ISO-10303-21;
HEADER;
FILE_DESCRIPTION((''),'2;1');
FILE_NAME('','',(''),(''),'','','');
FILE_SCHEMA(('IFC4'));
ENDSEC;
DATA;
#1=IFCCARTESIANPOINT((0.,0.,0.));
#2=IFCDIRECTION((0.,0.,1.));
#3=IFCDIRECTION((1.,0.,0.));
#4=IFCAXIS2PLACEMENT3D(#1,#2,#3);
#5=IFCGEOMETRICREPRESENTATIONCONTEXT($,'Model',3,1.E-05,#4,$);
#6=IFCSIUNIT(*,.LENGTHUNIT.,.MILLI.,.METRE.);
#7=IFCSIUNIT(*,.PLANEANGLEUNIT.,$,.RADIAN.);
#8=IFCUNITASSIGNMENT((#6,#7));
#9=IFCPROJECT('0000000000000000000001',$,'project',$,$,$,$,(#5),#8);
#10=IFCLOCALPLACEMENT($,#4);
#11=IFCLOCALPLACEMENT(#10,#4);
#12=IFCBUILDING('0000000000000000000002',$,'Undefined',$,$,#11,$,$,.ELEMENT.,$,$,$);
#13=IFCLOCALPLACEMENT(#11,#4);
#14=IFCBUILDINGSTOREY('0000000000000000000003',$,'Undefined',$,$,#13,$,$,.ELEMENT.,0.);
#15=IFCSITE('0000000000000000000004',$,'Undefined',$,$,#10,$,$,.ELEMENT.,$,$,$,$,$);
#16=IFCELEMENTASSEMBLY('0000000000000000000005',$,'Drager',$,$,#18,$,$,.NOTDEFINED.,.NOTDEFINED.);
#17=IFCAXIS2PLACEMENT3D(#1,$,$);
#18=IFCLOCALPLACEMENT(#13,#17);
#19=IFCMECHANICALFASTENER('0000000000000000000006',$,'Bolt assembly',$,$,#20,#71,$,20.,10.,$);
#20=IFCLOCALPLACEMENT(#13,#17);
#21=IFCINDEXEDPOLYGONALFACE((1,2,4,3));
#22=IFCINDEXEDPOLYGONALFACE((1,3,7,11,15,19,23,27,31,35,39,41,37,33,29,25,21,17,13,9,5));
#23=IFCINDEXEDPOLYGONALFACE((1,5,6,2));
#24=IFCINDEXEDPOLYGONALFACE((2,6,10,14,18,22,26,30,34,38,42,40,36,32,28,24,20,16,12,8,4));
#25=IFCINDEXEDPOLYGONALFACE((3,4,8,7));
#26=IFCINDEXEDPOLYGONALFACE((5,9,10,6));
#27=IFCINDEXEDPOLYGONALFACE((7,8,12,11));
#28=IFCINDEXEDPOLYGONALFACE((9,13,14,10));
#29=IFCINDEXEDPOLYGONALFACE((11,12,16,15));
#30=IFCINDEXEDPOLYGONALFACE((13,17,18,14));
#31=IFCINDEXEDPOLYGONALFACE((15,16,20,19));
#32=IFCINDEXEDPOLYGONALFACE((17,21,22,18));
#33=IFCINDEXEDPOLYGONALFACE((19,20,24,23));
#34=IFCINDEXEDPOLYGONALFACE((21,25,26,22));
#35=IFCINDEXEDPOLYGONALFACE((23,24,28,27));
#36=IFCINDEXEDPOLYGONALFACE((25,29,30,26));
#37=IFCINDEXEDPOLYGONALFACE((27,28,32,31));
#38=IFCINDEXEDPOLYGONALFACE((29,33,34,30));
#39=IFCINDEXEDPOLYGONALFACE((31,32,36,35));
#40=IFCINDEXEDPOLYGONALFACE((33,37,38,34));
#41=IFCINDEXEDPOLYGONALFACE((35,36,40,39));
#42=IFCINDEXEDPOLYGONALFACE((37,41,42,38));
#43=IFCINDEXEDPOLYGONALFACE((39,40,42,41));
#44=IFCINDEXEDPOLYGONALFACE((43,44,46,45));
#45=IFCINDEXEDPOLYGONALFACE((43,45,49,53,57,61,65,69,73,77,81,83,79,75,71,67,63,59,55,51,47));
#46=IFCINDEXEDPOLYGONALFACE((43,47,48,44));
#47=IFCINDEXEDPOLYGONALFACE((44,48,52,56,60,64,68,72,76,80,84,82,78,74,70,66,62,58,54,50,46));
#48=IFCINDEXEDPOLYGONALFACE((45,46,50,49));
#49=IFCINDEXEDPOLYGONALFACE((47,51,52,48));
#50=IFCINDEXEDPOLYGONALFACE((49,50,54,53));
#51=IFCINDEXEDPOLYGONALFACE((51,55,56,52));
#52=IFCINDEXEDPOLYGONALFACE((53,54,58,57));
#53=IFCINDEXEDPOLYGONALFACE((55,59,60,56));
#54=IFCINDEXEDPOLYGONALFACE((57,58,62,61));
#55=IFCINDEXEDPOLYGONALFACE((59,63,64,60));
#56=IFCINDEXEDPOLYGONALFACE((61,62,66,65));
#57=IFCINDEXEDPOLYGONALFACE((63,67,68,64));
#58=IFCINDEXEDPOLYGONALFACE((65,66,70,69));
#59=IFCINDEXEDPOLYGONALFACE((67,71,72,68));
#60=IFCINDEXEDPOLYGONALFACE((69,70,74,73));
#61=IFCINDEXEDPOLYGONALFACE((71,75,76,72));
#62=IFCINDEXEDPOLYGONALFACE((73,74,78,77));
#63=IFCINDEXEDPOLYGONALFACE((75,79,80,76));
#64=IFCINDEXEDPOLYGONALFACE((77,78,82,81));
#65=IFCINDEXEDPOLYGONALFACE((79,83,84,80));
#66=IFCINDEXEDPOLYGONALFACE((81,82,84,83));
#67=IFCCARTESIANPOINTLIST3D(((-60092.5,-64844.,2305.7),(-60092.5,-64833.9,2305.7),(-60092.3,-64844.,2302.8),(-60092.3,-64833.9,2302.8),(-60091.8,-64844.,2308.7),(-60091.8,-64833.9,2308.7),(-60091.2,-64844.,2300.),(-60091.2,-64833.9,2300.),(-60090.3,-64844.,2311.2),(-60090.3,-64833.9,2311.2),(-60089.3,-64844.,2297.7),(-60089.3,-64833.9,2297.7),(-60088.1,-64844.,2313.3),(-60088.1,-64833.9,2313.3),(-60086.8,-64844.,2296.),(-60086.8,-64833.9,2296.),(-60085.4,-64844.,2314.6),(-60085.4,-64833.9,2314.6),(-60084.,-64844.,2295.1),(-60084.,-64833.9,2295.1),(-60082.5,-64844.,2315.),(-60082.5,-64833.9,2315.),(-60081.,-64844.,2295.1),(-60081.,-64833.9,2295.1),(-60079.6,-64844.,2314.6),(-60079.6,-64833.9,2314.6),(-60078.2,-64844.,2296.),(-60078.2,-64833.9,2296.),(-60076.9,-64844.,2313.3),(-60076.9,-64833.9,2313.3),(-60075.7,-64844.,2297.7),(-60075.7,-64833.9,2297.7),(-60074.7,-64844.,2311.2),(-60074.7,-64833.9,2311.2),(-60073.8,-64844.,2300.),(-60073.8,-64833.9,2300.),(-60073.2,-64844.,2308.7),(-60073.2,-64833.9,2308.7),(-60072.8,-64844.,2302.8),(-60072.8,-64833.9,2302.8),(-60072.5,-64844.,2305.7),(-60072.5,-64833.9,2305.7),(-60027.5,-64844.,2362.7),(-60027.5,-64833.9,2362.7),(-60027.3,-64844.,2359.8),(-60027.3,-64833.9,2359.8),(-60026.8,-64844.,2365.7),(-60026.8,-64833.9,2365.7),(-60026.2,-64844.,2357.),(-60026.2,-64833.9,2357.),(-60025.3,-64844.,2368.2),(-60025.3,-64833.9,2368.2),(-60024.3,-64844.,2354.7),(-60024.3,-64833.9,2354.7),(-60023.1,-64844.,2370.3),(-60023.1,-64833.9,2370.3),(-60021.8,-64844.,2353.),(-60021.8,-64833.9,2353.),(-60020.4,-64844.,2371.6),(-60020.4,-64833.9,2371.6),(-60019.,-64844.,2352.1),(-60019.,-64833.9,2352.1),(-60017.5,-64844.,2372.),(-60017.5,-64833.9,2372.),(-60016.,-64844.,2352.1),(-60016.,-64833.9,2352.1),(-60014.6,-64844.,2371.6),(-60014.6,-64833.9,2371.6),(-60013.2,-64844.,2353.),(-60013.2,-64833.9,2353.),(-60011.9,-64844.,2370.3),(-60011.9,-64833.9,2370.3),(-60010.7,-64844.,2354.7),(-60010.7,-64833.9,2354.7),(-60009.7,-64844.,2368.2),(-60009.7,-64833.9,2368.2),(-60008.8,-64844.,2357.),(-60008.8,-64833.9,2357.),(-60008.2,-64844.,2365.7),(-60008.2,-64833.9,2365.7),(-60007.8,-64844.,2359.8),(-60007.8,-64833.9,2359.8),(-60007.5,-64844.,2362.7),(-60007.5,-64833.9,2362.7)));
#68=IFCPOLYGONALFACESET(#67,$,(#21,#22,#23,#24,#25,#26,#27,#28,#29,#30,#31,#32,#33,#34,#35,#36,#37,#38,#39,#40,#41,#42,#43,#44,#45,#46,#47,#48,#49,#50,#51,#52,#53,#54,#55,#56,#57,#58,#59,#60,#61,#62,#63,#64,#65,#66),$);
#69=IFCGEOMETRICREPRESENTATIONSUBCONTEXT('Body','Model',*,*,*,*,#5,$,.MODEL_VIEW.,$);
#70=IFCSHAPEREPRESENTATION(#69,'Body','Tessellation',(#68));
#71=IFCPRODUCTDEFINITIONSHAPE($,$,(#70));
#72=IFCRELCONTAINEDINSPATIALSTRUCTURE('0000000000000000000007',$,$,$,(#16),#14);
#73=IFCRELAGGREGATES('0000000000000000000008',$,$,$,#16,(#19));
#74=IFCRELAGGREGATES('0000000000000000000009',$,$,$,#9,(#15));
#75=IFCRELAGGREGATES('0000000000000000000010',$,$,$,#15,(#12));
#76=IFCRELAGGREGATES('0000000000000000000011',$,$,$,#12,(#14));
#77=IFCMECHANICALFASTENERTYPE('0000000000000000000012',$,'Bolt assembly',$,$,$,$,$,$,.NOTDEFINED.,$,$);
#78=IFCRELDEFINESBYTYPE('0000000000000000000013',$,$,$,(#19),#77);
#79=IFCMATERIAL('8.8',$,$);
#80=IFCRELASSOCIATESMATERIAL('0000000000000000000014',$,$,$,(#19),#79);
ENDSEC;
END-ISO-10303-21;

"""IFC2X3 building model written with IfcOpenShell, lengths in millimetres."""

from ifc_helpers import new_model, si_unit, frame, origin_with_axes, origin_2d_with_axis, place, context, subcontext, project, spatial, circle, extrude, source, transform, mapped, material, type_object, element, aggregate, save


model = new_model("IFC2X3")

# Units and contexts
model_context = context("Model", 3, precision=1e-05, world=origin_with_axes())
body_context = subcontext(model_context, "Body", "Model", "MODEL_VIEW")
ifc_project = project(units=[si_unit("LENGTHUNIT", "METRE", prefix="MILLI"), si_unit("PLANEANGLEUNIT", "RADIAN")], contexts=[model_context])

# Site, building, storey
site_placement = place(None, origin_with_axes())
site = spatial("IfcSite", under=ifc_project, at=site_placement, Name="Undefined", CompositionType="ELEMENT")
building_placement = place(site_placement, origin_with_axes())
building = spatial("IfcBuilding", under=site, at=building_placement, Name="Undefined", CompositionType="ELEMENT")
storey_placement = place(building_placement, origin_with_axes())
storey = spatial("IfcBuildingStorey", under=building, at=storey_placement, Name="Undefined", CompositionType="ELEMENT", Elevation=0.0)

# Shared definitions
ifc_material_1 = material(Name="8.8")
mechanical_fastener_type = type_object("IfcMechanicalFastenerType", Name="Bolt assembly")
shared_shape_1 = source(origin_with_axes(), body_context, "Body", "SweptSolid", [
    extrude(circle(Radius=10.0, at=origin_2d_with_axis()), frame((0.0, 0.0, 0.0), z_axis=(0.0, 1.0, 0.0), x_axis=(1.0, 0.0, 0.0)), (0.0, 0.0, 1.0), 10.1),
])

# Element assembly, mechanical fastener
assembly_1_placement = place(storey_placement, origin_with_axes())
assembly_1 = element("IfcElementAssembly", 1, at=assembly_1_placement, inside=storey, Name="Drager", AssemblyPlace="NOTDEFINED", PredefinedType="NOTDEFINED")
mechanical_fastener_1_placement = place(assembly_1_placement, frame((-60050.0, -64844.0, 2305.0), z_axis=(-1.0, 0.0, 0.0), x_axis=(0.0, 0.0, 1.0)))
mechanical_fastener_1 = element("IfcMechanicalFastener", 2, at=mechanical_fastener_1_placement, type_object=mechanical_fastener_type, material=ifc_material_1, Name="Bolt assembly", NominalDiameter=20.0, NominalLength=10.0, context=body_context, shape_type="MappedRepresentation", body=[
    mapped(shared_shape_1, transform((57.0, 0.0, -32.5))),
    mapped(shared_shape_1, transform((0.0, 0.0, 32.5))),
])
aggregate(assembly_1, [mechanical_fastener_1])

save(model, "model.ifc")
